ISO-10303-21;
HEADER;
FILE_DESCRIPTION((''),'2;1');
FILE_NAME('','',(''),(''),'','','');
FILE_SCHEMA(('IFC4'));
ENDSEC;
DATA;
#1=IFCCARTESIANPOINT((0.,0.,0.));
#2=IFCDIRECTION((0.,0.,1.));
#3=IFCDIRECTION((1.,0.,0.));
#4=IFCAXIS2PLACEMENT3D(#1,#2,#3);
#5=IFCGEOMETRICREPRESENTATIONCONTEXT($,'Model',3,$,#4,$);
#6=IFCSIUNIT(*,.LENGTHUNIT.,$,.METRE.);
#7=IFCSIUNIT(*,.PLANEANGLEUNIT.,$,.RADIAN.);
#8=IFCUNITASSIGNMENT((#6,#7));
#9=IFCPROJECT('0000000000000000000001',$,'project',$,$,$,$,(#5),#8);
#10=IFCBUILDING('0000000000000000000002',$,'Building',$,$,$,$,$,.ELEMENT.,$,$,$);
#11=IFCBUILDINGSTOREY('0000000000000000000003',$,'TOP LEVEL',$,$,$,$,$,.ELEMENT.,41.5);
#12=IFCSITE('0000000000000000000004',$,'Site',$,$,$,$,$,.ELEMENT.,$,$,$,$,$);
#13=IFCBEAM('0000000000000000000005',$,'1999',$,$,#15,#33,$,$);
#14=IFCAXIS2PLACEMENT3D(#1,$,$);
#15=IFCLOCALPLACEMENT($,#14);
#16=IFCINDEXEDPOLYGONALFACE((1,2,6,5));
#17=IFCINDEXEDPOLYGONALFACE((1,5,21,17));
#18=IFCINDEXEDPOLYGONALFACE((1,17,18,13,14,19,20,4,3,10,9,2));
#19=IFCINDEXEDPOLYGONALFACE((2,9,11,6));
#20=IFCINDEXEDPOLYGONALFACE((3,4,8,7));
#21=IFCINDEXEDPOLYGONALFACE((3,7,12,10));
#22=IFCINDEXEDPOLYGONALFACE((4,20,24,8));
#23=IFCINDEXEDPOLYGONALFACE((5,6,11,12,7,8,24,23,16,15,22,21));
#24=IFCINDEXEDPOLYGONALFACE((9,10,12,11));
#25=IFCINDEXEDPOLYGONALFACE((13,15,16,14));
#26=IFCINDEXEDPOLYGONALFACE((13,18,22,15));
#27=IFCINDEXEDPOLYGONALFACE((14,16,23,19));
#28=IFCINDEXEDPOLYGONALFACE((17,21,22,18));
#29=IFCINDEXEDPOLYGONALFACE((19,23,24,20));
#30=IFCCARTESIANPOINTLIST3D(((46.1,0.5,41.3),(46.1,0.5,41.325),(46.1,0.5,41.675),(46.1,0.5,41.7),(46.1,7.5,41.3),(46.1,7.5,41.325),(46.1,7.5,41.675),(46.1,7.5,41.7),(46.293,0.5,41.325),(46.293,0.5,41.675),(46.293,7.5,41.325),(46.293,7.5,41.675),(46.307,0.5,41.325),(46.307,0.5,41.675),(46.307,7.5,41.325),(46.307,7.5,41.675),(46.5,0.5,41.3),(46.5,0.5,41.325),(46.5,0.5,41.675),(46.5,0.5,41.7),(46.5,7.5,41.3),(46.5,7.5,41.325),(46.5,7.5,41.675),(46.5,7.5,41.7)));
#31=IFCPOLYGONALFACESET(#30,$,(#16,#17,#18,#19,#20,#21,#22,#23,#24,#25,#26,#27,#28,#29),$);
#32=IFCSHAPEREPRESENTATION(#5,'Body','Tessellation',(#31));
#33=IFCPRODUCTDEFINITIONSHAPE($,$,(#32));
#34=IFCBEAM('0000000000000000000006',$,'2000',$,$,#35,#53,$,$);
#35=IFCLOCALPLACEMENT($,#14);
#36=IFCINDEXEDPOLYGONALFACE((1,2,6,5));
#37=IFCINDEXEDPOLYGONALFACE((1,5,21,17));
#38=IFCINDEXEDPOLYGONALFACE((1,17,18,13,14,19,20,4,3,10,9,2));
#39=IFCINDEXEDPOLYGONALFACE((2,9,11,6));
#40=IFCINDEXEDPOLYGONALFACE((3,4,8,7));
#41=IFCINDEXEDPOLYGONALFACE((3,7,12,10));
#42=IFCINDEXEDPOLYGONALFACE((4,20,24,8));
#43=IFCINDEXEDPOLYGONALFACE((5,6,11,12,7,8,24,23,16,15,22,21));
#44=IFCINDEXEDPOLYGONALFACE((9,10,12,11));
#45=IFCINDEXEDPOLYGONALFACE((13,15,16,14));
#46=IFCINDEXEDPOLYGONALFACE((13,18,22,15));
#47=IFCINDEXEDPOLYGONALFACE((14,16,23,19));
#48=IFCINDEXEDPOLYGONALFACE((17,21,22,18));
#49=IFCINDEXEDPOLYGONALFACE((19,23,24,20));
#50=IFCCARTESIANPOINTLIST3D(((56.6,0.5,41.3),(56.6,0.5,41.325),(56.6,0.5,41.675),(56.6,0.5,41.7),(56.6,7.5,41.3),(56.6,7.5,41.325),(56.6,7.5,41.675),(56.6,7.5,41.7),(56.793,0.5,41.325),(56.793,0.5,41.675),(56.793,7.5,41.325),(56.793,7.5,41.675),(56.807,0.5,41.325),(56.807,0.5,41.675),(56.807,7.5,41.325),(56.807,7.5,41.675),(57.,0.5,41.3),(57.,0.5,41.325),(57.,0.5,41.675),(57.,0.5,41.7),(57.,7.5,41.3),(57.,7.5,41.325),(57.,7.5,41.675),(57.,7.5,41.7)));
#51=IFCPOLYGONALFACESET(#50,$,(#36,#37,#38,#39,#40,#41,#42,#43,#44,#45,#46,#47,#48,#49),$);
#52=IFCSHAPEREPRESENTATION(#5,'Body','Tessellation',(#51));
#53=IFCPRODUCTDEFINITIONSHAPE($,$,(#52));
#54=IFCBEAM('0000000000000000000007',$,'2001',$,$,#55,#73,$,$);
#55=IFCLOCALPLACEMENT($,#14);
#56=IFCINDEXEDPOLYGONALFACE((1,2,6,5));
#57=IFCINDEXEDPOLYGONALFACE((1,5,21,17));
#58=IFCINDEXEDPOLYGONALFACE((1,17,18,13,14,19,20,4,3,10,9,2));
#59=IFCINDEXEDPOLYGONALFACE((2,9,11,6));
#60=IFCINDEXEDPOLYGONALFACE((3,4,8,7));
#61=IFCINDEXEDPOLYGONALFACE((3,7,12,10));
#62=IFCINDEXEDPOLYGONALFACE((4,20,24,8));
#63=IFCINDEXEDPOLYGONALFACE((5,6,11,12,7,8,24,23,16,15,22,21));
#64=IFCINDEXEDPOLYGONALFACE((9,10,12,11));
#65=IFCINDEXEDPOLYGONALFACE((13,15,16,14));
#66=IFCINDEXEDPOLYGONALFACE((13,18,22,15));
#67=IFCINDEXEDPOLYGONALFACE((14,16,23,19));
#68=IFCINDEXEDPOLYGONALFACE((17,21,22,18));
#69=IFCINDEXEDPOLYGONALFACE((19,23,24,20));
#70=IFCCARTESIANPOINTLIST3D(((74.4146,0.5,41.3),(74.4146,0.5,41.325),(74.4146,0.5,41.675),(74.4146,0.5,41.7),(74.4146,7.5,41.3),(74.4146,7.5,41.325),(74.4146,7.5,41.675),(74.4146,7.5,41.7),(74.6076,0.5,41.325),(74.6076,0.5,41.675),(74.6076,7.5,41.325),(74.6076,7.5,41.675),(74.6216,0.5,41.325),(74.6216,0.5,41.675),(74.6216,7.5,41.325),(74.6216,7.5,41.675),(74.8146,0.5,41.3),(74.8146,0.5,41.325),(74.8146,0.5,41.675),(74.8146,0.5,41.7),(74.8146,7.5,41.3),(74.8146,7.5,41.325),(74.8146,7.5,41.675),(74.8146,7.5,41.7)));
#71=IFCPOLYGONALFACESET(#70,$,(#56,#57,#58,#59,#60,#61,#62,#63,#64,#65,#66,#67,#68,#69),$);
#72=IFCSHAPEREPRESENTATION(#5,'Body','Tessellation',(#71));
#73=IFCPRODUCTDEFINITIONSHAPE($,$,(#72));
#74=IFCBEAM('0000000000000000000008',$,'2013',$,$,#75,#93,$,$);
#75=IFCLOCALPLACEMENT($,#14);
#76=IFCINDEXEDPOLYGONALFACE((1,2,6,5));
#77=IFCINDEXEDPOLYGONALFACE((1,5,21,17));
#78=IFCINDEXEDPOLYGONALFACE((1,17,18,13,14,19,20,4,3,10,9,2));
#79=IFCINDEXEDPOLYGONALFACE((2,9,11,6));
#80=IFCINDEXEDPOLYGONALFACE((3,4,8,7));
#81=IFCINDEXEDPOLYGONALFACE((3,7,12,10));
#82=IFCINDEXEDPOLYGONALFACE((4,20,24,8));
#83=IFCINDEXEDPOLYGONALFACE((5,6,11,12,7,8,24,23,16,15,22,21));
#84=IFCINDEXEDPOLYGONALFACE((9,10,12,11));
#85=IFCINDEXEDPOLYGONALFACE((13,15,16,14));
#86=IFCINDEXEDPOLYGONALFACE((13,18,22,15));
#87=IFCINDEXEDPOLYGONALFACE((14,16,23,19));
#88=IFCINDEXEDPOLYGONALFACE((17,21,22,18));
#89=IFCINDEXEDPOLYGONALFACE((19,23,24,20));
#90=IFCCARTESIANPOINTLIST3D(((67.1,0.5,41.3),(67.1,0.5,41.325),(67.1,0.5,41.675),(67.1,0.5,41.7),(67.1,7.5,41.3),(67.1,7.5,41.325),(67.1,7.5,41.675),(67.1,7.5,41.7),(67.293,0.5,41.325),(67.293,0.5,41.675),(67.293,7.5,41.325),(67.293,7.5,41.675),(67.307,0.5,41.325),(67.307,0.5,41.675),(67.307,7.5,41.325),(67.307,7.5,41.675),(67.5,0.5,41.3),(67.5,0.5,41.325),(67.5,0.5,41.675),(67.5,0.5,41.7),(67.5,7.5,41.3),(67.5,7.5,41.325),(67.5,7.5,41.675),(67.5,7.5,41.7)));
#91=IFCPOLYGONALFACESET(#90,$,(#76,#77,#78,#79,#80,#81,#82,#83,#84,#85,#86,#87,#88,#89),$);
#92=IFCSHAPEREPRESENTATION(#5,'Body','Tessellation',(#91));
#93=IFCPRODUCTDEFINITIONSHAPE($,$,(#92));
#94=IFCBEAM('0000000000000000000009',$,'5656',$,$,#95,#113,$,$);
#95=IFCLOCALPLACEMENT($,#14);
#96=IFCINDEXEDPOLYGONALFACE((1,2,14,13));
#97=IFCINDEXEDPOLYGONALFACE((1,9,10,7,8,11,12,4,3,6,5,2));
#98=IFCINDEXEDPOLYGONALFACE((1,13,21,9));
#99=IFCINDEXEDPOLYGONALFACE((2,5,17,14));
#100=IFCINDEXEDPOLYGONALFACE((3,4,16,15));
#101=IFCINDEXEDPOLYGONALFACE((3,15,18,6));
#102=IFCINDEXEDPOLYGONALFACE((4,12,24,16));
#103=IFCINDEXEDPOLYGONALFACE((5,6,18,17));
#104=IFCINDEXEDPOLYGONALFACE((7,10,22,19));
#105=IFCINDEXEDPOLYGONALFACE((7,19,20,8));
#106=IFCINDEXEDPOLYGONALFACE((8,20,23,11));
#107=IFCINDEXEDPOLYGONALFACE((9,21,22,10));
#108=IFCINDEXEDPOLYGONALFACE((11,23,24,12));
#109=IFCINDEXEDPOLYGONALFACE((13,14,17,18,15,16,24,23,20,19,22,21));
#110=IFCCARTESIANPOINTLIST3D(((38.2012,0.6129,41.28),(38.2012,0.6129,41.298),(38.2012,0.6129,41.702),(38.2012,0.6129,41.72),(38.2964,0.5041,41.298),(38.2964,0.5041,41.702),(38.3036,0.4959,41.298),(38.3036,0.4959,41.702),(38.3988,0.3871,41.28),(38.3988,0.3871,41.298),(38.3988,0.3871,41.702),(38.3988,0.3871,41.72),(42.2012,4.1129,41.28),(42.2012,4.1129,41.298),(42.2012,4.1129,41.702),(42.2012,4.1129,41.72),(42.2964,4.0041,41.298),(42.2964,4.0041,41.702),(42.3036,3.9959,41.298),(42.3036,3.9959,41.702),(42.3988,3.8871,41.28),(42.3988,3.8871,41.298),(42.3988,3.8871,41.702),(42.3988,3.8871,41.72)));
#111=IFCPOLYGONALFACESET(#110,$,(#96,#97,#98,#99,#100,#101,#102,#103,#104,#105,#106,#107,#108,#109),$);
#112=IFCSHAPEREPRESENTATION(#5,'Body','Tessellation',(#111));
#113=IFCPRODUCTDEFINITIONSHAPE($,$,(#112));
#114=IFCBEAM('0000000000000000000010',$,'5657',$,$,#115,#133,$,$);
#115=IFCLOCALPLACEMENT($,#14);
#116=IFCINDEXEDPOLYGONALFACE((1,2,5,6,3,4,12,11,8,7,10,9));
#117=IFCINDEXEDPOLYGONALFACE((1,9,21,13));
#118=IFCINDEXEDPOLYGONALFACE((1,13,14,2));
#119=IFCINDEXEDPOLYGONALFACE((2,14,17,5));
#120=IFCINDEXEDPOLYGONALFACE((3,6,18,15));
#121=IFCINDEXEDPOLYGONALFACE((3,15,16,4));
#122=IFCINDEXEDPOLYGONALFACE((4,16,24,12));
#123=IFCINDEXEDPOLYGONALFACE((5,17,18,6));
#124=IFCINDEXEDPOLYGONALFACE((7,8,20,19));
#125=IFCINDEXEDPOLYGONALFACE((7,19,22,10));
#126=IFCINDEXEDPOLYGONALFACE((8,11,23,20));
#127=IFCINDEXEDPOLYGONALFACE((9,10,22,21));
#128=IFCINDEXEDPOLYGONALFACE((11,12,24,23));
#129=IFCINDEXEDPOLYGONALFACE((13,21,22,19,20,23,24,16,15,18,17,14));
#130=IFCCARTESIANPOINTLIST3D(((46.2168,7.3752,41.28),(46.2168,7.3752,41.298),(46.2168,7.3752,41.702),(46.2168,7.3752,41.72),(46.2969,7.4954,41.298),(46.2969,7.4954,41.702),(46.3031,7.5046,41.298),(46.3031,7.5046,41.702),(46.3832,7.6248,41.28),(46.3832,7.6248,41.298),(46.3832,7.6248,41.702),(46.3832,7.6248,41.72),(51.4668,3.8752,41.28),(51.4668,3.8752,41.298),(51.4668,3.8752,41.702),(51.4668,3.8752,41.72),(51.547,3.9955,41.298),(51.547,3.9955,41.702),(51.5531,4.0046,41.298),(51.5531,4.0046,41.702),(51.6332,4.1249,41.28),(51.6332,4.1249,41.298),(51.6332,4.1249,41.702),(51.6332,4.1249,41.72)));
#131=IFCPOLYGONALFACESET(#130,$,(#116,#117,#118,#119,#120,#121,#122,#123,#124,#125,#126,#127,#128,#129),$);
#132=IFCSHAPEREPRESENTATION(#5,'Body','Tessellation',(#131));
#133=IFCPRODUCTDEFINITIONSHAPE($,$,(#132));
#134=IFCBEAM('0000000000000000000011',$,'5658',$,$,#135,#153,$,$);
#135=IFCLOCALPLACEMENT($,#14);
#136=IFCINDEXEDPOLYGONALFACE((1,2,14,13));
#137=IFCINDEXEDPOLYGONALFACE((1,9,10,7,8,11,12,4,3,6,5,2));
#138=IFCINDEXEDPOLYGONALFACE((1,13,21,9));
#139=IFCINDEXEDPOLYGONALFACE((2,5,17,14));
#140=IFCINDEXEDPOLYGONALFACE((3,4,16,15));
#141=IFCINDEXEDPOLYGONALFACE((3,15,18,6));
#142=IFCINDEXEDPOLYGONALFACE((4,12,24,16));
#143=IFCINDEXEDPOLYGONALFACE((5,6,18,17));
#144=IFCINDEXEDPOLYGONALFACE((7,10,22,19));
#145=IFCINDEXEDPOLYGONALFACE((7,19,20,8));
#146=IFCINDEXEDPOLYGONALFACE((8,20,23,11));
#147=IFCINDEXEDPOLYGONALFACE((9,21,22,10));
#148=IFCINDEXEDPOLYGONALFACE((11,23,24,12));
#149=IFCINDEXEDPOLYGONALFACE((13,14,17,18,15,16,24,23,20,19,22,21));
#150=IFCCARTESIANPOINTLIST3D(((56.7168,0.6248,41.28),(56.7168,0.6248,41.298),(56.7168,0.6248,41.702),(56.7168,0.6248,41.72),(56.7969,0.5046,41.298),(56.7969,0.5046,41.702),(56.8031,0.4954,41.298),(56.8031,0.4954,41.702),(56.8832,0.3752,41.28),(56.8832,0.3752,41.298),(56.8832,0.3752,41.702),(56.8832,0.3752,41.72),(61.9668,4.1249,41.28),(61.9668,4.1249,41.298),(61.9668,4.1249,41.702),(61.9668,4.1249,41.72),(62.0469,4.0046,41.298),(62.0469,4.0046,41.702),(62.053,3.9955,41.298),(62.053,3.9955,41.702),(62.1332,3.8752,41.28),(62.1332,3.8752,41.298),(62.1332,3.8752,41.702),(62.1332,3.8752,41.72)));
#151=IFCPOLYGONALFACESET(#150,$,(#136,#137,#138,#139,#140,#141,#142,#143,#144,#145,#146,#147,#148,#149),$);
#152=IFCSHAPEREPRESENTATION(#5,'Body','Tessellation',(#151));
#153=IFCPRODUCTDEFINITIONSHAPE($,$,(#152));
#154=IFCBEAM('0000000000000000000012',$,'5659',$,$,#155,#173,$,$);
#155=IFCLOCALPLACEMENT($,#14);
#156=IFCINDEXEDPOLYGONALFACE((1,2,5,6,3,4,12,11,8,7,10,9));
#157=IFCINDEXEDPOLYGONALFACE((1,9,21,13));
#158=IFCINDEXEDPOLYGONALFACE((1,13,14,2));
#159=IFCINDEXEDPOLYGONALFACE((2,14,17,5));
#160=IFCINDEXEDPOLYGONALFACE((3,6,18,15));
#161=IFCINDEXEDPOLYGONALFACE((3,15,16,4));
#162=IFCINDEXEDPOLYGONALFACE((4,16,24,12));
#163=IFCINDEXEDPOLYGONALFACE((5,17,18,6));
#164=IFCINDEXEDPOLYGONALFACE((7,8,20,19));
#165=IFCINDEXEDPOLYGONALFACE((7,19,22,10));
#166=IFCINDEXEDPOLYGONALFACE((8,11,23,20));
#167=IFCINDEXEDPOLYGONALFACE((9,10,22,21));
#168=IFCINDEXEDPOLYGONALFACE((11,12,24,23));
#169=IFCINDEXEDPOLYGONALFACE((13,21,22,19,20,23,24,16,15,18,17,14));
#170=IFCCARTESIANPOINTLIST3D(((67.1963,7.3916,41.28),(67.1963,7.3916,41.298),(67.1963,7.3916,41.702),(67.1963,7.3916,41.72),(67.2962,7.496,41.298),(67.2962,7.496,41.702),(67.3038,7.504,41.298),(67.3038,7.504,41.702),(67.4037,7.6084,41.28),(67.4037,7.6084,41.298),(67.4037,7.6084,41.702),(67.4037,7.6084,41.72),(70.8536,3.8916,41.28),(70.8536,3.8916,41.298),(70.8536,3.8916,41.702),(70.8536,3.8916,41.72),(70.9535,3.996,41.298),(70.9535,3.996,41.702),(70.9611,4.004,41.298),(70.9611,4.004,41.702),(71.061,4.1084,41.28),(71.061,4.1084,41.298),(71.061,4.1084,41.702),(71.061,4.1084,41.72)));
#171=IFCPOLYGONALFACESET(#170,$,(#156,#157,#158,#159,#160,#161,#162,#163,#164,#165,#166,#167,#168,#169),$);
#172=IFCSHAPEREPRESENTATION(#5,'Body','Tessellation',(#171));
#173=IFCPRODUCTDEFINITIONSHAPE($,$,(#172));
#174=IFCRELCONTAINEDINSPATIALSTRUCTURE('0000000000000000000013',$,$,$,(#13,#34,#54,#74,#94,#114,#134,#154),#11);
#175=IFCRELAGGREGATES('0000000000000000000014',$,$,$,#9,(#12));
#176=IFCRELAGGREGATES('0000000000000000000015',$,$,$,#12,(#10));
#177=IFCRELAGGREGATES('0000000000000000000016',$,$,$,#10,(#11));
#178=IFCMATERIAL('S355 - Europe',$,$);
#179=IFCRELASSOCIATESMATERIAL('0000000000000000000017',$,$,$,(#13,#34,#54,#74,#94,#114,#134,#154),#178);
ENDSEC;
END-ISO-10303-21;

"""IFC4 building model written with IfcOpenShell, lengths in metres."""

from ifc_helpers import new_model, si_unit, frame, origin_with_axes, origin_2d_with_axis, place, context, project, spatial, i_section, extrude, material, material_profile, profile_set, profile_usage, element, save


model = new_model("IFC4")

# Units and contexts
model_context = context("Model", 3, world=origin_with_axes())
ifc_project = project(units=[si_unit("LENGTHUNIT", "METRE"), si_unit("PLANEANGLEUNIT", "RADIAN")], contexts=[model_context])

# Site, building, storey
site = spatial("IfcSite", under=ifc_project, Name="Site", CompositionType="ELEMENT")
building = spatial("IfcBuilding", under=site, Name="Building", CompositionType="ELEMENT")
storey = spatial("IfcBuildingStorey", under=building, Name="TOP LEVEL", CompositionType="ELEMENT", Elevation=41.5)

# Beams
ifc_material = material(Name="S355 - Europe")
ifc_material_profile_1 = material_profile(ifc_material, i_section(OverallWidth=0.4, OverallDepth=0.4, WebThickness=0.014, FlangeThickness=0.025, at=origin_2d_with_axis()))
ifc_profile_set_1 = profile_set([ifc_material_profile_1])
ifc_profile_usage_1 = profile_usage(ifc_profile_set_1, cardinal=10)
beam_1_placement = place(None, frame((46.3, 7.5, 41.5), z_axis=(0.0, -1.0, 0.0), x_axis=(1.0, 0.0, 0.0)))
element("IfcBeam", 1, at=beam_1_placement, inside=storey, material=ifc_profile_usage_1, Name="1999", context=model_context, shape_type="SweptSolid", body=[
    extrude(i_section(OverallWidth=0.4, OverallDepth=0.4, WebThickness=0.014, FlangeThickness=0.025, at=origin_2d_with_axis()), origin_with_axes(), (0.0, 0.0, 1.0), 7.0),
])
ifc_material_profile_2 = material_profile(ifc_material, i_section(OverallWidth=0.4, OverallDepth=0.4, WebThickness=0.014, FlangeThickness=0.025, at=origin_2d_with_axis()))
ifc_profile_set_2 = profile_set([ifc_material_profile_2])
ifc_profile_usage_2 = profile_usage(ifc_profile_set_2, cardinal=10)
beam_2_placement = place(None, frame((56.8, 7.5, 41.5), z_axis=(0.0, -1.0, 0.0), x_axis=(1.0, 0.0, 0.0)))
element("IfcBeam", 2, at=beam_2_placement, inside=storey, material=ifc_profile_usage_2, Name="2000", context=model_context, shape_type="SweptSolid", body=[
    extrude(i_section(OverallWidth=0.4, OverallDepth=0.4, WebThickness=0.014, FlangeThickness=0.025, at=origin_2d_with_axis()), origin_with_axes(), (0.0, 0.0, 1.0), 7.0),
])
ifc_material_profile_3 = material_profile(ifc_material, i_section(OverallWidth=0.4, OverallDepth=0.4, WebThickness=0.014, FlangeThickness=0.025, at=origin_2d_with_axis()))
ifc_profile_set_3 = profile_set([ifc_material_profile_3])
ifc_profile_usage_3 = profile_usage(ifc_profile_set_3, cardinal=10)
beam_3_placement = place(None, frame((74.6146, 7.5, 41.5), z_axis=(0.0, -1.0, 0.0), x_axis=(1.0, 0.0, 0.0)))
element("IfcBeam", 3, at=beam_3_placement, inside=storey, material=ifc_profile_usage_3, Name="2001", context=model_context, shape_type="SweptSolid", body=[
    extrude(i_section(OverallWidth=0.4, OverallDepth=0.4, WebThickness=0.014, FlangeThickness=0.025, at=origin_2d_with_axis()), origin_with_axes(), (0.0, 0.0, 1.0), 7.0),
])
ifc_material_profile_4 = material_profile(ifc_material, i_section(OverallWidth=0.4, OverallDepth=0.4, WebThickness=0.014, FlangeThickness=0.025, at=origin_2d_with_axis()))
ifc_profile_set_4 = profile_set([ifc_material_profile_4])
ifc_profile_usage_4 = profile_usage(ifc_profile_set_4, cardinal=10)
beam_4_placement = place(None, frame((67.3, 7.5, 41.5), z_axis=(0.0, -1.0, 0.0), x_axis=(1.0, 0.0, 0.0)))
element("IfcBeam", 4, at=beam_4_placement, inside=storey, material=ifc_profile_usage_4, Name="2013", context=model_context, shape_type="SweptSolid", body=[
    extrude(i_section(OverallWidth=0.4, OverallDepth=0.4, WebThickness=0.014, FlangeThickness=0.025, at=origin_2d_with_axis()), origin_with_axes(), (0.0, 0.0, 1.0), 7.0),
])
ifc_material_profile_5 = material_profile(ifc_material, i_section(OverallWidth=0.3, OverallDepth=0.44, WebThickness=0.011, FlangeThickness=0.018, at=origin_2d_with_axis()))
ifc_profile_set_5 = profile_set([ifc_material_profile_5])
ifc_profile_usage_5 = profile_usage(ifc_profile_set_5, cardinal=10)
beam_5_placement = place(None, frame((38.3, 0.5, 41.5), z_axis=(0.752577, 0.658505, 0.0), x_axis=(-0.658505, 0.752577, 0.0)))
element("IfcBeam", 5, at=beam_5_placement, inside=storey, material=ifc_profile_usage_5, Name="5656", context=model_context, shape_type="SweptSolid", body=[
    extrude(i_section(OverallWidth=0.3, OverallDepth=0.44, WebThickness=0.011, FlangeThickness=0.018, at=origin_2d_with_axis()), origin_with_axes(), (0.0, 0.0, 1.0), 5.3151),
])
ifc_material_profile_6 = material_profile(ifc_material, i_section(OverallWidth=0.3, OverallDepth=0.44, WebThickness=0.011, FlangeThickness=0.018, at=origin_2d_with_axis()))
ifc_profile_set_6 = profile_set([ifc_material_profile_6])
ifc_profile_usage_6 = profile_usage(ifc_profile_set_6, cardinal=10)
beam_6_placement = place(None, frame((46.3, 7.5, 41.5), z_axis=(0.832055, -0.554693, 0.0), x_axis=(0.554693, 0.832055, 0.0)))
element("IfcBeam", 6, at=beam_6_placement, inside=storey, material=ifc_profile_usage_6, Name="5657", context=model_context, shape_type="SweptSolid", body=[
    extrude(i_section(OverallWidth=0.3, OverallDepth=0.44, WebThickness=0.011, FlangeThickness=0.018, at=origin_2d_with_axis()), origin_with_axes(), (0.0, 0.0, 1.0), 6.3097),
])
ifc_material_profile_7 = material_profile(ifc_material, i_section(OverallWidth=0.3, OverallDepth=0.44, WebThickness=0.011, FlangeThickness=0.018, at=origin_2d_with_axis()))
ifc_profile_set_7 = profile_set([ifc_material_profile_7])
ifc_profile_usage_7 = profile_usage(ifc_profile_set_7, cardinal=10)
beam_7_placement = place(None, frame((56.8, 0.5, 41.5), z_axis=(0.832045, 0.554708, 0.0), x_axis=(-0.554708, 0.832045, 0.0)))
element("IfcBeam", 7, at=beam_7_placement, inside=storey, material=ifc_profile_usage_7, Name="5658", context=model_context, shape_type="SweptSolid", body=[
    extrude(i_section(OverallWidth=0.3, OverallDepth=0.44, WebThickness=0.011, FlangeThickness=0.018, at=origin_2d_with_axis()), origin_with_axes(), (0.0, 0.0, 1.0), 6.3097),
])
ifc_material_profile_8 = material_profile(ifc_material, i_section(OverallWidth=0.3, OverallDepth=0.44, WebThickness=0.011, FlangeThickness=0.018, at=origin_2d_with_axis()))
ifc_profile_set_8 = profile_set([ifc_material_profile_8])
ifc_profile_usage_8 = profile_usage(ifc_profile_set_8, cardinal=10)
beam_8_placement = place(None, frame((67.3, 7.5, 41.5), z_axis=(0.722473, -0.691399, 0.0), x_axis=(0.691399, 0.722473, 0.0)))
element("IfcBeam", 8, at=beam_8_placement, inside=storey, material=ifc_profile_usage_8, Name="5659", context=model_context, shape_type="SweptSolid", body=[
    extrude(i_section(OverallWidth=0.3, OverallDepth=0.44, WebThickness=0.011, FlangeThickness=0.018, at=origin_2d_with_axis()), origin_with_axes(), (0.0, 0.0, 1.0), 5.0622),
])

save(model, "model.ifc")
